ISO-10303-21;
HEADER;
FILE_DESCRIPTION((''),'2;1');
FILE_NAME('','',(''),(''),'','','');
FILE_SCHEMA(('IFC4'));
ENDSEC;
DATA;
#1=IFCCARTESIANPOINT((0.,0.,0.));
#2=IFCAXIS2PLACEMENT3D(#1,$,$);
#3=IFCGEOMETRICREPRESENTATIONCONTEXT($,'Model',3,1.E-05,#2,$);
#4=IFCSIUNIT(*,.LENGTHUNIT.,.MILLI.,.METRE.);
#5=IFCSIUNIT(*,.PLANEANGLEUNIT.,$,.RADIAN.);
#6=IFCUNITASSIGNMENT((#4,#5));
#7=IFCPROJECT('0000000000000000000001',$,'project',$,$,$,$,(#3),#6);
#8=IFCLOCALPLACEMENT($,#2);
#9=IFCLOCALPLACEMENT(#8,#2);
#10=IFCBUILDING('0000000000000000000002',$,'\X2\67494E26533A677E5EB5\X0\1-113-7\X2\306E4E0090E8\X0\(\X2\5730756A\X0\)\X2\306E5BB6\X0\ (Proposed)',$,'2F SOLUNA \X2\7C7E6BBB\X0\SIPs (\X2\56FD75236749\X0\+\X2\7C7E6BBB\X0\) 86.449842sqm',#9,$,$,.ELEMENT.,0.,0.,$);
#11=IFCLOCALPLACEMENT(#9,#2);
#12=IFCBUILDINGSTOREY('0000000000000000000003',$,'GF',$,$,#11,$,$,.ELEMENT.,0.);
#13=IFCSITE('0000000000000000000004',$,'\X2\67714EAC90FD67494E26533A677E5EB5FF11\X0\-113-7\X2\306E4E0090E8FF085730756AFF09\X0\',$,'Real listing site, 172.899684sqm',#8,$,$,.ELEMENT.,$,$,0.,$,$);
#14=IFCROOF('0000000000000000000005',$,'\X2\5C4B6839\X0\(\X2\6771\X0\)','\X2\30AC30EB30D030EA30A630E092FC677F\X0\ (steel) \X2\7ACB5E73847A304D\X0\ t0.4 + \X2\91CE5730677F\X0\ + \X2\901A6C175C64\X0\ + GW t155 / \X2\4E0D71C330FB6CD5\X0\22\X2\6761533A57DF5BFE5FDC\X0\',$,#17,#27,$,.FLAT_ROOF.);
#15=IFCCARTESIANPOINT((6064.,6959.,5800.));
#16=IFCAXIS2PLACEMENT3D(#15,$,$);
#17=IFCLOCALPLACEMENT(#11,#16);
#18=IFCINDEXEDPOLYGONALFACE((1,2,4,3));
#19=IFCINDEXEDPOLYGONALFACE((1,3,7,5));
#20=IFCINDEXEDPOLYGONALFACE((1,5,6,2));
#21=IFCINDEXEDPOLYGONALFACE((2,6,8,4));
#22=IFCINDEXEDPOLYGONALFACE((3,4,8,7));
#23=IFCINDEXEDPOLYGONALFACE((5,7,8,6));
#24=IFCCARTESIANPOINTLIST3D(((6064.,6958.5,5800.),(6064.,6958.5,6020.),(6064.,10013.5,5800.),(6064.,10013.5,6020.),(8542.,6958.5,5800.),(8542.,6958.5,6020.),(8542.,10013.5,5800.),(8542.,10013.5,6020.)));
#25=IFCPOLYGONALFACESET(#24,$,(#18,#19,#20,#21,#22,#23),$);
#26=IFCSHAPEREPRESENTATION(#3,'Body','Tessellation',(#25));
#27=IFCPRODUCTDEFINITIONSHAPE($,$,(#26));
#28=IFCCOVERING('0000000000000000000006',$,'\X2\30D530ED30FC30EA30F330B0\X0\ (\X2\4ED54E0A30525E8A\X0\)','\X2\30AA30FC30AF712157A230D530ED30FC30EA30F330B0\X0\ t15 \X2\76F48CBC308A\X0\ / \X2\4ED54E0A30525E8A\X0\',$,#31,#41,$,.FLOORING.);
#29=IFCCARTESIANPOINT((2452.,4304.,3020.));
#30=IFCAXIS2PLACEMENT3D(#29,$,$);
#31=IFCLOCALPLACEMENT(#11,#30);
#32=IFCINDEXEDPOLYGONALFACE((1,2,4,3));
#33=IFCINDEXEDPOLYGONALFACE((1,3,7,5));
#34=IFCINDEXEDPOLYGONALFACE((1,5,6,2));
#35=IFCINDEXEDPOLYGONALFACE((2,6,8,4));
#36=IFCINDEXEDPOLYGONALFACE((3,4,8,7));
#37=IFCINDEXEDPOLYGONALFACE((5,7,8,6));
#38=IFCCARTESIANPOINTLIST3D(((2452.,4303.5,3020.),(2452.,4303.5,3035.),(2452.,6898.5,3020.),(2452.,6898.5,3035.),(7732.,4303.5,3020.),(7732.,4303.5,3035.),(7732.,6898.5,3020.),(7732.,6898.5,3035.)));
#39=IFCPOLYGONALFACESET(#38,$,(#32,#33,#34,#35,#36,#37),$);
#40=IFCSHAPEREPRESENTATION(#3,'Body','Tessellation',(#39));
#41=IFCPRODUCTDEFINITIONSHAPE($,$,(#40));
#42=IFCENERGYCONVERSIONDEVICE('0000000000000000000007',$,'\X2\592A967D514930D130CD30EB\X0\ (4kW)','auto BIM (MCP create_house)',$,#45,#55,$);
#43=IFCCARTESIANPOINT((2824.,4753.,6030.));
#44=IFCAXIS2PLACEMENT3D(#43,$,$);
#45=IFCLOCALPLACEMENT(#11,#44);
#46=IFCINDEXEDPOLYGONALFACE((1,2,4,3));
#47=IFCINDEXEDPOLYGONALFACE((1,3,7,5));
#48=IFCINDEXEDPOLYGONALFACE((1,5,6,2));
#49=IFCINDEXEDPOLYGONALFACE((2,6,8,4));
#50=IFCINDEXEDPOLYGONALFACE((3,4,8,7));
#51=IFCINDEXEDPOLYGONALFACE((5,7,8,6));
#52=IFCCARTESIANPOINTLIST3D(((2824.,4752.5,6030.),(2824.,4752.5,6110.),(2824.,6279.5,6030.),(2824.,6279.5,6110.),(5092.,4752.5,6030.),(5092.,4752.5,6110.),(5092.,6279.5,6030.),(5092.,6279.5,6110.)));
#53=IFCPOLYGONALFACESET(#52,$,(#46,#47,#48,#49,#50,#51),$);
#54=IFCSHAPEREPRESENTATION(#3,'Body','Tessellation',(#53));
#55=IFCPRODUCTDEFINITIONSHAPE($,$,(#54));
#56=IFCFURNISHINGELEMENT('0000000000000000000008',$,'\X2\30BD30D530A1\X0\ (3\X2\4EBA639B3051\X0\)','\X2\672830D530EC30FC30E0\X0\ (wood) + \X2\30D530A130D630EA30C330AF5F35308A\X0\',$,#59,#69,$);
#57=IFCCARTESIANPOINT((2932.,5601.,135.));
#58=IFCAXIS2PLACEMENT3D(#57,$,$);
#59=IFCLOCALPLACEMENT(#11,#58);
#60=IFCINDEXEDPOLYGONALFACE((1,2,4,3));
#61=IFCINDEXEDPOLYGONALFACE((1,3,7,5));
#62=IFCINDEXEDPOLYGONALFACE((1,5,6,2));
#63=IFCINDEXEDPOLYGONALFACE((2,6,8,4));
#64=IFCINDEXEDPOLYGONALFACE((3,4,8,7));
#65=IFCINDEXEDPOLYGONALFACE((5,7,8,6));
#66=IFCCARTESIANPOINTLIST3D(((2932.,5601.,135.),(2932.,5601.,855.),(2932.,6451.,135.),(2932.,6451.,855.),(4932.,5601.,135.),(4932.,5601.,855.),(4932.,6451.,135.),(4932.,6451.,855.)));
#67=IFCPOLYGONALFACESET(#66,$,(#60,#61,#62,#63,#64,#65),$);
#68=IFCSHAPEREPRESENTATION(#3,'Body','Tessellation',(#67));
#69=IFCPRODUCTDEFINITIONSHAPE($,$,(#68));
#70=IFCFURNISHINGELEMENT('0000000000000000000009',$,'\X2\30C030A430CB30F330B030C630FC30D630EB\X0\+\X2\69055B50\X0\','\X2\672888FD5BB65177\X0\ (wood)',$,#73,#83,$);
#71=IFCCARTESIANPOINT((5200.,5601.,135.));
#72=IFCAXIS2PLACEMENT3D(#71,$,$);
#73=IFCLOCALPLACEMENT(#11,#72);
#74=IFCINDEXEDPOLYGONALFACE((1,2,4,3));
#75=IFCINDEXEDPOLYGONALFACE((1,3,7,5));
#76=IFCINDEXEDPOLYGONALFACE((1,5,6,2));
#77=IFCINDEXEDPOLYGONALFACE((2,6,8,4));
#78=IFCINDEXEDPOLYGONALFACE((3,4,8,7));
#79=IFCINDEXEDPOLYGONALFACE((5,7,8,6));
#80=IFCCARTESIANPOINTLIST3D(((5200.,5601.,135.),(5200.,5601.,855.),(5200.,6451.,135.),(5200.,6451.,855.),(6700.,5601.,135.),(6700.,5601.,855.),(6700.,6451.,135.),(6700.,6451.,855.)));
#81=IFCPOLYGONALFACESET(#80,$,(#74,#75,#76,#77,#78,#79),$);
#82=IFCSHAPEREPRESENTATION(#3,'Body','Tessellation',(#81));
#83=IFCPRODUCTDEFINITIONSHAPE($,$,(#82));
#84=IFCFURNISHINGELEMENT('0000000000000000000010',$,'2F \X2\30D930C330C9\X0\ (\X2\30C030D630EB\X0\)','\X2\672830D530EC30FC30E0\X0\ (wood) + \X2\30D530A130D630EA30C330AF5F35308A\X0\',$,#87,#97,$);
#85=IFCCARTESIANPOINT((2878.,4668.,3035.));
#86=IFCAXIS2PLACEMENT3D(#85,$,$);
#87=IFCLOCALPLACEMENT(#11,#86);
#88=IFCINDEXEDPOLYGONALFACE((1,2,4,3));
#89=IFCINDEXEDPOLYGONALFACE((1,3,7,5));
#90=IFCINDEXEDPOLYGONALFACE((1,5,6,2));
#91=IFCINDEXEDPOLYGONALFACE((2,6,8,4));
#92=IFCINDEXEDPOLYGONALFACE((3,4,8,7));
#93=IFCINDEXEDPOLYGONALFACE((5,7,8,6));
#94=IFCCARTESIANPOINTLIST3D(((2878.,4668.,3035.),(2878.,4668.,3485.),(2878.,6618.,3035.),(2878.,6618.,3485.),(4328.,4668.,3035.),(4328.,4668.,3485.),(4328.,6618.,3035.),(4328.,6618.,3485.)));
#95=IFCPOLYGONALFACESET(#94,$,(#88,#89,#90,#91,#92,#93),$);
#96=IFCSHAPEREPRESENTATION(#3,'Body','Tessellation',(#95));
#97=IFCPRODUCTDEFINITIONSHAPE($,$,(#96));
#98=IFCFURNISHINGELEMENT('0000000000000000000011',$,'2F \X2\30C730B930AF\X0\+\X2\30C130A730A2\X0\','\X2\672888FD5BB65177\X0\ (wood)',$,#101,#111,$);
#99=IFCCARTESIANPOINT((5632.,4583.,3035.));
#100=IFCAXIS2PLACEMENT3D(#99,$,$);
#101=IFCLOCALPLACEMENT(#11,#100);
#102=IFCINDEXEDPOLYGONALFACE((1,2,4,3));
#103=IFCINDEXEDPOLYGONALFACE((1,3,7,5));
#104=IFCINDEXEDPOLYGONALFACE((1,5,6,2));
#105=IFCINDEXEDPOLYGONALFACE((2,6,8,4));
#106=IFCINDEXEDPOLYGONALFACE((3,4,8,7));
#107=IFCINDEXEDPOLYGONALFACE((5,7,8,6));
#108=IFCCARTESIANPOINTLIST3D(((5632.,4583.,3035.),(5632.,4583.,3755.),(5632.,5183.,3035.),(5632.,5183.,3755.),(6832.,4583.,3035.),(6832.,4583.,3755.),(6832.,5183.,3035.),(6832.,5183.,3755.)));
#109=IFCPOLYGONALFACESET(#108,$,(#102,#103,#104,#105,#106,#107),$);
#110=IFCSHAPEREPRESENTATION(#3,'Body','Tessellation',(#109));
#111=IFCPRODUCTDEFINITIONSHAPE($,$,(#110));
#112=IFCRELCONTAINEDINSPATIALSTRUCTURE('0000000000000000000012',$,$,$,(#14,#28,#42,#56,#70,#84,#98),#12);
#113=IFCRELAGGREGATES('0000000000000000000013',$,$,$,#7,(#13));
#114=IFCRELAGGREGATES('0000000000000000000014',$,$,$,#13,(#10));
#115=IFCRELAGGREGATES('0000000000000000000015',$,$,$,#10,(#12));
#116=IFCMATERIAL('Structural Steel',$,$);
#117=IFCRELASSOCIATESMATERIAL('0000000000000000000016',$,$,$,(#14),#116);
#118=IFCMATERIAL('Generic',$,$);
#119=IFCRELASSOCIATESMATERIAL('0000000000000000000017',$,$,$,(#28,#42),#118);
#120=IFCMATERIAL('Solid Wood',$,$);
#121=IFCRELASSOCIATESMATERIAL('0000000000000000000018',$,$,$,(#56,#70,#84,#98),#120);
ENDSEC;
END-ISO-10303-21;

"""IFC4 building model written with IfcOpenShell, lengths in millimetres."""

from ifc_helpers import new_model, si_unit, frame, frame_2d, origin, place, context, project, spatial, rectangle, extrude, material, element, save


model = new_model("IFC4")

# Units and contexts
model_context = context("Model", 3, precision=1e-05, world=origin())
ifc_project = project(units=[si_unit("LENGTHUNIT", "METRE", prefix="MILLI"), si_unit("PLANEANGLEUNIT", "RADIAN")], contexts=[model_context])

# Site, building, storey
site_placement = place(None, origin())
site = spatial("IfcSite", under=ifc_project, at=site_placement, Name="東京都杉並区松庵１-113-7の一部（地番）", ObjectType="Real listing site, 172.899684sqm", CompositionType="ELEMENT", RefElevation=0.0)
building_placement = place(site_placement, origin())
building = spatial("IfcBuilding", under=site, at=building_placement, Name="杉並区松庵1-113-7の一部(地番)の家 (Proposed)", ObjectType="2F SOLUNA 籾殻SIPs (国産杉+籾殻) 86.449842sqm", CompositionType="ELEMENT", ElevationOfRefHeight=0.0, ElevationOfTerrain=0.0)
storey_placement = place(building_placement, origin())
storey = spatial("IfcBuildingStorey", under=building, at=storey_placement, Name="GF", CompositionType="ELEMENT", Elevation=0.0)

# Shared definitions
ifc_material_1 = material(Name="Solid Wood")

# Roof
ifc_material_2 = material(Name="Structural Steel")
roof_1_placement = place(storey_placement, frame((6064.0, 6959.0, 5800.0)))
element("IfcRoof", 1, at=roof_1_placement, inside=storey, material=ifc_material_2, Name="屋根(東)", Description="ガルバリウム鋼板 (steel) 立平葺き t0.4 + 野地板 + 通気層 + GW t155 / 不燃・法22条区域対応", PredefinedType="FLAT_ROOF", context=model_context, shape_type="SweptSolid", body=[
    extrude(rectangle(XDim=2478.0, YDim=3055.0, at=frame_2d((1239.0, 1527.0))), frame((6064.0, 6959.0, 5800.0)), (0.0, 0.0, 1.0), 220.0),
])

# Covering
ifc_material_3 = material(Name="Generic")
covering_placement = place(storey_placement, frame((2452.0, 4304.0, 3020.0)))
element("IfcCovering", 2, at=covering_placement, inside=storey, material=ifc_material_3, Name="フローリング (仕上げ床)", Description="オーク無垢フローリング t15 直貼り / 仕上げ床", PredefinedType="FLOORING", context=model_context, shape_type="SweptSolid", body=[
    extrude(rectangle(XDim=5280.0, YDim=2595.0, at=frame_2d((2640.0, 1297.0))), frame((2452.0, 4304.0, 3020.0)), (0.0, 0.0, 1.0), 15.0),
])

# Energy conversion device
energy_conversion_device_placement = place(storey_placement, frame((2824.0, 4753.0, 6030.0)))
element("IfcEnergyConversionDevice", 3, at=energy_conversion_device_placement, inside=storey, material=ifc_material_3, Name="太陽光パネル (4kW)", Description="auto BIM (MCP create_house)", context=model_context, shape_type="SweptSolid", body=[
    extrude(rectangle(XDim=2268.0, YDim=1527.0, at=frame_2d((1134.0, 763.0))), frame((2824.0, 4753.0, 6030.0)), (0.0, 0.0, 1.0), 80.0),
])

# Furnishing elements
furnishing_1_placement = place(storey_placement, frame((2932.0, 5601.0, 135.0)))
element("IfcFurnishingElement", 4, at=furnishing_1_placement, inside=storey, material=ifc_material_1, Name="ソファ (3人掛け)", Description="木フレーム (wood) + ファブリック張り", context=model_context, shape_type="SweptSolid", body=[
    extrude(rectangle(XDim=2000.0, YDim=850.0, at=frame_2d((1000.0, 425.0))), frame((2932.0, 5601.0, 135.0)), (0.0, 0.0, 1.0), 720.0),
])
furnishing_2_placement = place(storey_placement, frame((5200.0, 5601.0, 135.0)))
element("IfcFurnishingElement", 5, at=furnishing_2_placement, inside=storey, material=ifc_material_1, Name="ダイニングテーブル+椅子", Description="木製家具 (wood)", context=model_context, shape_type="SweptSolid", body=[
    extrude(rectangle(XDim=1500.0, YDim=850.0, at=frame_2d((750.0, 425.0))), frame((5200.0, 5601.0, 135.0)), (0.0, 0.0, 1.0), 720.0),
])
furnishing_3_placement = place(storey_placement, frame((2878.0, 4668.0, 3035.0)))
element("IfcFurnishingElement", 6, at=furnishing_3_placement, inside=storey, material=ifc_material_1, Name="2F ベッド (ダブル)", Description="木フレーム (wood) + ファブリック張り", context=model_context, shape_type="SweptSolid", body=[
    extrude(rectangle(XDim=1450.0, YDim=1950.0, at=frame_2d((725.0, 975.0))), frame((2878.0, 4668.0, 3035.0)), (0.0, 0.0, 1.0), 450.0),
])
furnishing_4_placement = place(storey_placement, frame((5632.0, 4583.0, 3035.0)))
element("IfcFurnishingElement", 7, at=furnishing_4_placement, inside=storey, material=ifc_material_1, Name="2F デスク+チェア", Description="木製家具 (wood)", context=model_context, shape_type="SweptSolid", body=[
    extrude(rectangle(XDim=1200.0, YDim=600.0, at=frame_2d((600.0, 300.0))), frame((5632.0, 4583.0, 3035.0)), (0.0, 0.0, 1.0), 720.0),
])

save(model, "model.ifc")
